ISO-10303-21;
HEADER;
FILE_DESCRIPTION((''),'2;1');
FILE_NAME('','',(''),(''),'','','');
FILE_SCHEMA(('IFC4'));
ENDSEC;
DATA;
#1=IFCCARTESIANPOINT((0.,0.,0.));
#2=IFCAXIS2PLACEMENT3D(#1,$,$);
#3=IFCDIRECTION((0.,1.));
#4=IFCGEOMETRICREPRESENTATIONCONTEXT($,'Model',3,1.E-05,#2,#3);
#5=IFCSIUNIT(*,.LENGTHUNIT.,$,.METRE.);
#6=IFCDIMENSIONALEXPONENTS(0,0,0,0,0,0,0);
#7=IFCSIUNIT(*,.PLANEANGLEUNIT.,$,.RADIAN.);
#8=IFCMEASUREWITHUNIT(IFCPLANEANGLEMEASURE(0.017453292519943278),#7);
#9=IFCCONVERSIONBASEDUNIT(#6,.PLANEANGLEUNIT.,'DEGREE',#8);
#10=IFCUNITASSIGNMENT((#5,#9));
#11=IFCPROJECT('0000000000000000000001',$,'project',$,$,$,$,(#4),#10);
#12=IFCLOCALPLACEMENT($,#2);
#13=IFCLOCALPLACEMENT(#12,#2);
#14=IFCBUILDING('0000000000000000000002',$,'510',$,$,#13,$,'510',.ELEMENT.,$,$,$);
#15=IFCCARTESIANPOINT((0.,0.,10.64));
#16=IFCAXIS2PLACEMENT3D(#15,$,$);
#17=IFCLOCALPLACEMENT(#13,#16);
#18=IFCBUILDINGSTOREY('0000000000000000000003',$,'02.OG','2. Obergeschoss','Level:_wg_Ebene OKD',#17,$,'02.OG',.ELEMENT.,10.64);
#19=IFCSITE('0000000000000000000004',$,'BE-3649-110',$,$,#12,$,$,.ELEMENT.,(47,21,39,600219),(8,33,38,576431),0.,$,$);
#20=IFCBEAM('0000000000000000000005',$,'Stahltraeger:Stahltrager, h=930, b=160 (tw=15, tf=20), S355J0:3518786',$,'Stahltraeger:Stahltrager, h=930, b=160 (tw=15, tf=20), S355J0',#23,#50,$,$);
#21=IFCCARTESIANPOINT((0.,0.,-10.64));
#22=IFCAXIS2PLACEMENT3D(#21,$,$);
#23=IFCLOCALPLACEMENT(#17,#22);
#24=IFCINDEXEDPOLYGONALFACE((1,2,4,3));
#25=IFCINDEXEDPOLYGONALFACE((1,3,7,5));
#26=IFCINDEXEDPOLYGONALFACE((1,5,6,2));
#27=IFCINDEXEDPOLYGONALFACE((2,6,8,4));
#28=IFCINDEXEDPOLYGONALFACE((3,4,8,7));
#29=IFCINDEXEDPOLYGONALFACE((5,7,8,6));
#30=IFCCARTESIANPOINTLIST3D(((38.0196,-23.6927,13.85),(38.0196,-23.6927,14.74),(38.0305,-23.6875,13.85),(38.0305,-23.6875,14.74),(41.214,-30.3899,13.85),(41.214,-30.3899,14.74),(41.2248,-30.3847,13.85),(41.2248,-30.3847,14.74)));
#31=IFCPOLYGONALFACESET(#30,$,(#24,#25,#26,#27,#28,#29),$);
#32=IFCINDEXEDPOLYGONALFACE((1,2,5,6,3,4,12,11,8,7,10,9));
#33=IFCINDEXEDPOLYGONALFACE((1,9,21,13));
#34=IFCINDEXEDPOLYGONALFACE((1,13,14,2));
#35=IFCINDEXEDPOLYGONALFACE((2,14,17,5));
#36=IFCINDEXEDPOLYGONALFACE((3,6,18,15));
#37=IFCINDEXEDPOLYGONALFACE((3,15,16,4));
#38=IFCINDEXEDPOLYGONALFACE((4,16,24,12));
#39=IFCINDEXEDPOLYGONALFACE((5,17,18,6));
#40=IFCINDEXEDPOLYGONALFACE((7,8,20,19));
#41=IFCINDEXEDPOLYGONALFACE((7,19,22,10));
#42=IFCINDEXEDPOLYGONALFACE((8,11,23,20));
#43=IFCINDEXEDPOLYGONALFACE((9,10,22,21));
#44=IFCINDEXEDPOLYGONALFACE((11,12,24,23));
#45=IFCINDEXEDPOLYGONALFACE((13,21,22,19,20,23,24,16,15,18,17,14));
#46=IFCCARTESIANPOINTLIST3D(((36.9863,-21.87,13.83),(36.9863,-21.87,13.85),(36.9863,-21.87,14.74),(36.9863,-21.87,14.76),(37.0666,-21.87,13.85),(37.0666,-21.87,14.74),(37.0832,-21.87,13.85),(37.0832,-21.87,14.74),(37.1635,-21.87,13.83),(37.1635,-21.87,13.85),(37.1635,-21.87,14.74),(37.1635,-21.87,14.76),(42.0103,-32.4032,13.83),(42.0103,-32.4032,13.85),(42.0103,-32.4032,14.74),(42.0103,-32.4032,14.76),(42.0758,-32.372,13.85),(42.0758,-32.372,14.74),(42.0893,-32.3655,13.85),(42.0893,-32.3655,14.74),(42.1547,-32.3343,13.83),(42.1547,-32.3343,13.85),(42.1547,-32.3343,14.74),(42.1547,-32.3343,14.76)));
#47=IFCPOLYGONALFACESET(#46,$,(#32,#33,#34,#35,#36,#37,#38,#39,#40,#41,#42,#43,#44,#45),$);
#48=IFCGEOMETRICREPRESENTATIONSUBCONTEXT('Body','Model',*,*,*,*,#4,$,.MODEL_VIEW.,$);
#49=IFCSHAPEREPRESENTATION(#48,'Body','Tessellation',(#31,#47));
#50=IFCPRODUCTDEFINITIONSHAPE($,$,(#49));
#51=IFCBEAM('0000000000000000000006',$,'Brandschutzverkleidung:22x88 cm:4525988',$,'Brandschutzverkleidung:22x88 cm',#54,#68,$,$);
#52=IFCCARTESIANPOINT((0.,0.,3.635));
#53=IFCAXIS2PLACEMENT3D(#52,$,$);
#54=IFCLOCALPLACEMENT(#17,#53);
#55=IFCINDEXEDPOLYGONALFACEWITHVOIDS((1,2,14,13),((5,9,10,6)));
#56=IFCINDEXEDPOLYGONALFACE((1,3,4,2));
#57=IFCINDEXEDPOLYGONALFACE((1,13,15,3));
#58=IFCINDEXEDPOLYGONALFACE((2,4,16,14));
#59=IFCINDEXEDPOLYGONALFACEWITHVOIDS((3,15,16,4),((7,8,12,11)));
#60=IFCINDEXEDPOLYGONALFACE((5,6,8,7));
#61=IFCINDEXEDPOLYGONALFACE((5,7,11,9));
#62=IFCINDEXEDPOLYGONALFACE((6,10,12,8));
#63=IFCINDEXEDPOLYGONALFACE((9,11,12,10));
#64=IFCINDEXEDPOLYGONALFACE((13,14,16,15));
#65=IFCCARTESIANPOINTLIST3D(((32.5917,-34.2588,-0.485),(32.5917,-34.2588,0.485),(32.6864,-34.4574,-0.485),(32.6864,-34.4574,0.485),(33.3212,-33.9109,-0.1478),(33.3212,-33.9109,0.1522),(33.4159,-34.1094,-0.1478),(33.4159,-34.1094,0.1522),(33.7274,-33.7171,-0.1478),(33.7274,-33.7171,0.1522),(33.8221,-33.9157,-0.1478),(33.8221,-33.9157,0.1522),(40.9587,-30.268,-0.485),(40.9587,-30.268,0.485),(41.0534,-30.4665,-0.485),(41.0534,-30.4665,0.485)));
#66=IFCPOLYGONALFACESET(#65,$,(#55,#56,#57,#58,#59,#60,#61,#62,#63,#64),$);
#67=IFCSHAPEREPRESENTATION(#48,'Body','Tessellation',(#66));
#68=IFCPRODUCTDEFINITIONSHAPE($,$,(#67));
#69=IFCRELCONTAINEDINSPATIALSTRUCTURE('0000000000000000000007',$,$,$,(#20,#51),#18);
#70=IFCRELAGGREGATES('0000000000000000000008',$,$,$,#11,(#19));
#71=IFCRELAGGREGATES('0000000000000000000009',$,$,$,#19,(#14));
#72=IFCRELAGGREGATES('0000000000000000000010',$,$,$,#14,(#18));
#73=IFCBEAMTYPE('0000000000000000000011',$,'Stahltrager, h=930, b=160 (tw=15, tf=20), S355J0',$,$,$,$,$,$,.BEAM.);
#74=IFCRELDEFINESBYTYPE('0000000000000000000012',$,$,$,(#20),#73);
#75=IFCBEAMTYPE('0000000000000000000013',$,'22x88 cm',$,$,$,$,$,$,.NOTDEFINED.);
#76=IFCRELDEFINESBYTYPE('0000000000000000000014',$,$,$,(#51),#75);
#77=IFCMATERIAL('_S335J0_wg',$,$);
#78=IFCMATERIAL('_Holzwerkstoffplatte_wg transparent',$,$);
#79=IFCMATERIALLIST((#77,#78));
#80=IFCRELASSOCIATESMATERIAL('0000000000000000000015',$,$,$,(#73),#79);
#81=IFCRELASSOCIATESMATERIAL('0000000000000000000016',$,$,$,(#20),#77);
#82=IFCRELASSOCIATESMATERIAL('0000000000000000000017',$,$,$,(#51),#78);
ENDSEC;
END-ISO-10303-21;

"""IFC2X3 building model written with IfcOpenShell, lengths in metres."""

from ifc_helpers import new_model, entity, si_unit, converted_unit, direction, frame, frame_2d, origin, place, context, subcontext, project, spatial, polyline, rectangle, i_section, outline, extrude, clip, halfspace, source, transform, mapped, material, material_list, type_object, type_shapes, element, save


model = new_model("IFC2X3")

# Units and contexts
model_context = context("Model", 3, precision=1e-05, world=origin(), true_north=direction((0.0, 1.0)))
body_context = subcontext(model_context, "Body", "Model", "MODEL_VIEW")
ifc_project = project(units=[si_unit("LENGTHUNIT", "METRE"), converted_unit("PLANEANGLEUNIT", "DEGREE", entity("IfcPlaneAngleMeasure", 0.017453292519943278), si_unit("PLANEANGLEUNIT", "RADIAN"), dimensions=[0, 0, 0, 0, 0, 0, 0])], contexts=[model_context])

# Site, building, storey
site_placement = place(None, origin())
site = spatial("IfcSite", under=ifc_project, at=site_placement, Name="BE-3649-110", CompositionType="ELEMENT", RefLatitude=(47, 21, 39, 600219), RefLongitude=(8, 33, 38, 576431), RefElevation=0.0)
building_placement = place(site_placement, origin())
building = spatial("IfcBuilding", under=site, at=building_placement, Name="510", LongName="510", CompositionType="ELEMENT")
storey_placement = place(building_placement, frame((0.0, 0.0, 10.64)))
storey = spatial("IfcBuildingStorey", under=building, at=storey_placement, Name="02.OG", Description="2. Obergeschoss", ObjectType="Level:_wg_Ebene OKD", LongName="02.OG", CompositionType="ELEMENT", Elevation=10.64)

# Beams
ifc_material_1 = material(Name="_S335J0_wg")
ifc_material_2 = material(Name="_Holzwerkstoffplatte_wg transparent")
ifc_material_list = material_list([ifc_material_1, ifc_material_2])
beam_type_1 = type_object("IfcBeamType", Name="Stahltrager, h=930, b=160 (tw=15, tf=20), S355J0", PredefinedType="BEAM", material=ifc_material_list)
shared_shape_1 = source(origin(), body_context, "Body", "SweptSolid", [
    extrude(rectangle(XDim=0.89, YDim=0.012, at=frame_2d((0.0, 0.0), x_axis=(1.0, 0.0))), frame((38.025, -23.6901, 14.295), z_axis=(0.430511, -0.902585, 0.0), x_axis=(0.0, 0.0, -1.0)), (0.0, 0.0, 1.0), 7.42),
    clip(extrude(i_section(OverallWidth=0.16, OverallDepth=0.93, WebThickness=0.015, FlangeThickness=0.02, at=frame_2d((0.0, 0.0), x_axis=(0.0, 1.0))), frame((37.0585, -21.8356, 14.295), z_axis=(0.430511, -0.902585, 0.0), x_axis=(0.0, 0.0, -1.0)), (0.0, 0.0, 1.0), 11.67), halfspace(frame((37.73, -21.87, 10.78), z_axis=(0.0, 1.0, 0.0), x_axis=(1.0, 0.0, 0.0)), False)),
])
type_shapes(beam_type_1, [shared_shape_1])
beam_1_placement = place(storey_placement, frame((0.0, 0.0, -10.64)))
element("IfcBeam", 1, at=beam_1_placement, inside=storey, type_object=beam_type_1, material=ifc_material_1, Name="Stahltraeger:Stahltrager, h=930, b=160 (tw=15, tf=20), S355J0:3518786", ObjectType="Stahltraeger:Stahltrager, h=930, b=160 (tw=15, tf=20), S355J0", context=body_context, shape_type="MappedRepresentation", body=[
    mapped(shared_shape_1, transform((0.0, 0.0, 0.0), scale=1.0)),
])
beam_type_2 = type_object("IfcBeamType", Name="22x88 cm", PredefinedType="NOTDEFINED")
beam_2_placement = place(storey_placement, frame((0.0, 0.0, 3.635)))
element("IfcBeam", 2, at=beam_2_placement, inside=storey, type_object=beam_type_2, material=ifc_material_2, Name="Brandschutzverkleidung:22x88 cm:4525988", ObjectType="Brandschutzverkleidung:22x88 cm", context=body_context, shape_type="SweptSolid", body=[
    extrude(outline(polyline([(-4.635, -0.485), (4.635, -0.485), (4.635, 0.485), (-4.635, 0.485), (-4.635, -0.485)]), holes=[polyline([(3.3767, -0.1478), (3.3767, 0.1522), (3.8267, 0.1522), (3.8267, -0.1478), (3.3767, -0.1478)])]), frame((36.8699, -32.462, 0.0), z_axis=(-0.430511, 0.902585, 0.0), x_axis=(-0.902585, -0.430511, 0.0)), (0.0, 0.0, 1.0), 0.22),
])

save(model, "model.ifc")
